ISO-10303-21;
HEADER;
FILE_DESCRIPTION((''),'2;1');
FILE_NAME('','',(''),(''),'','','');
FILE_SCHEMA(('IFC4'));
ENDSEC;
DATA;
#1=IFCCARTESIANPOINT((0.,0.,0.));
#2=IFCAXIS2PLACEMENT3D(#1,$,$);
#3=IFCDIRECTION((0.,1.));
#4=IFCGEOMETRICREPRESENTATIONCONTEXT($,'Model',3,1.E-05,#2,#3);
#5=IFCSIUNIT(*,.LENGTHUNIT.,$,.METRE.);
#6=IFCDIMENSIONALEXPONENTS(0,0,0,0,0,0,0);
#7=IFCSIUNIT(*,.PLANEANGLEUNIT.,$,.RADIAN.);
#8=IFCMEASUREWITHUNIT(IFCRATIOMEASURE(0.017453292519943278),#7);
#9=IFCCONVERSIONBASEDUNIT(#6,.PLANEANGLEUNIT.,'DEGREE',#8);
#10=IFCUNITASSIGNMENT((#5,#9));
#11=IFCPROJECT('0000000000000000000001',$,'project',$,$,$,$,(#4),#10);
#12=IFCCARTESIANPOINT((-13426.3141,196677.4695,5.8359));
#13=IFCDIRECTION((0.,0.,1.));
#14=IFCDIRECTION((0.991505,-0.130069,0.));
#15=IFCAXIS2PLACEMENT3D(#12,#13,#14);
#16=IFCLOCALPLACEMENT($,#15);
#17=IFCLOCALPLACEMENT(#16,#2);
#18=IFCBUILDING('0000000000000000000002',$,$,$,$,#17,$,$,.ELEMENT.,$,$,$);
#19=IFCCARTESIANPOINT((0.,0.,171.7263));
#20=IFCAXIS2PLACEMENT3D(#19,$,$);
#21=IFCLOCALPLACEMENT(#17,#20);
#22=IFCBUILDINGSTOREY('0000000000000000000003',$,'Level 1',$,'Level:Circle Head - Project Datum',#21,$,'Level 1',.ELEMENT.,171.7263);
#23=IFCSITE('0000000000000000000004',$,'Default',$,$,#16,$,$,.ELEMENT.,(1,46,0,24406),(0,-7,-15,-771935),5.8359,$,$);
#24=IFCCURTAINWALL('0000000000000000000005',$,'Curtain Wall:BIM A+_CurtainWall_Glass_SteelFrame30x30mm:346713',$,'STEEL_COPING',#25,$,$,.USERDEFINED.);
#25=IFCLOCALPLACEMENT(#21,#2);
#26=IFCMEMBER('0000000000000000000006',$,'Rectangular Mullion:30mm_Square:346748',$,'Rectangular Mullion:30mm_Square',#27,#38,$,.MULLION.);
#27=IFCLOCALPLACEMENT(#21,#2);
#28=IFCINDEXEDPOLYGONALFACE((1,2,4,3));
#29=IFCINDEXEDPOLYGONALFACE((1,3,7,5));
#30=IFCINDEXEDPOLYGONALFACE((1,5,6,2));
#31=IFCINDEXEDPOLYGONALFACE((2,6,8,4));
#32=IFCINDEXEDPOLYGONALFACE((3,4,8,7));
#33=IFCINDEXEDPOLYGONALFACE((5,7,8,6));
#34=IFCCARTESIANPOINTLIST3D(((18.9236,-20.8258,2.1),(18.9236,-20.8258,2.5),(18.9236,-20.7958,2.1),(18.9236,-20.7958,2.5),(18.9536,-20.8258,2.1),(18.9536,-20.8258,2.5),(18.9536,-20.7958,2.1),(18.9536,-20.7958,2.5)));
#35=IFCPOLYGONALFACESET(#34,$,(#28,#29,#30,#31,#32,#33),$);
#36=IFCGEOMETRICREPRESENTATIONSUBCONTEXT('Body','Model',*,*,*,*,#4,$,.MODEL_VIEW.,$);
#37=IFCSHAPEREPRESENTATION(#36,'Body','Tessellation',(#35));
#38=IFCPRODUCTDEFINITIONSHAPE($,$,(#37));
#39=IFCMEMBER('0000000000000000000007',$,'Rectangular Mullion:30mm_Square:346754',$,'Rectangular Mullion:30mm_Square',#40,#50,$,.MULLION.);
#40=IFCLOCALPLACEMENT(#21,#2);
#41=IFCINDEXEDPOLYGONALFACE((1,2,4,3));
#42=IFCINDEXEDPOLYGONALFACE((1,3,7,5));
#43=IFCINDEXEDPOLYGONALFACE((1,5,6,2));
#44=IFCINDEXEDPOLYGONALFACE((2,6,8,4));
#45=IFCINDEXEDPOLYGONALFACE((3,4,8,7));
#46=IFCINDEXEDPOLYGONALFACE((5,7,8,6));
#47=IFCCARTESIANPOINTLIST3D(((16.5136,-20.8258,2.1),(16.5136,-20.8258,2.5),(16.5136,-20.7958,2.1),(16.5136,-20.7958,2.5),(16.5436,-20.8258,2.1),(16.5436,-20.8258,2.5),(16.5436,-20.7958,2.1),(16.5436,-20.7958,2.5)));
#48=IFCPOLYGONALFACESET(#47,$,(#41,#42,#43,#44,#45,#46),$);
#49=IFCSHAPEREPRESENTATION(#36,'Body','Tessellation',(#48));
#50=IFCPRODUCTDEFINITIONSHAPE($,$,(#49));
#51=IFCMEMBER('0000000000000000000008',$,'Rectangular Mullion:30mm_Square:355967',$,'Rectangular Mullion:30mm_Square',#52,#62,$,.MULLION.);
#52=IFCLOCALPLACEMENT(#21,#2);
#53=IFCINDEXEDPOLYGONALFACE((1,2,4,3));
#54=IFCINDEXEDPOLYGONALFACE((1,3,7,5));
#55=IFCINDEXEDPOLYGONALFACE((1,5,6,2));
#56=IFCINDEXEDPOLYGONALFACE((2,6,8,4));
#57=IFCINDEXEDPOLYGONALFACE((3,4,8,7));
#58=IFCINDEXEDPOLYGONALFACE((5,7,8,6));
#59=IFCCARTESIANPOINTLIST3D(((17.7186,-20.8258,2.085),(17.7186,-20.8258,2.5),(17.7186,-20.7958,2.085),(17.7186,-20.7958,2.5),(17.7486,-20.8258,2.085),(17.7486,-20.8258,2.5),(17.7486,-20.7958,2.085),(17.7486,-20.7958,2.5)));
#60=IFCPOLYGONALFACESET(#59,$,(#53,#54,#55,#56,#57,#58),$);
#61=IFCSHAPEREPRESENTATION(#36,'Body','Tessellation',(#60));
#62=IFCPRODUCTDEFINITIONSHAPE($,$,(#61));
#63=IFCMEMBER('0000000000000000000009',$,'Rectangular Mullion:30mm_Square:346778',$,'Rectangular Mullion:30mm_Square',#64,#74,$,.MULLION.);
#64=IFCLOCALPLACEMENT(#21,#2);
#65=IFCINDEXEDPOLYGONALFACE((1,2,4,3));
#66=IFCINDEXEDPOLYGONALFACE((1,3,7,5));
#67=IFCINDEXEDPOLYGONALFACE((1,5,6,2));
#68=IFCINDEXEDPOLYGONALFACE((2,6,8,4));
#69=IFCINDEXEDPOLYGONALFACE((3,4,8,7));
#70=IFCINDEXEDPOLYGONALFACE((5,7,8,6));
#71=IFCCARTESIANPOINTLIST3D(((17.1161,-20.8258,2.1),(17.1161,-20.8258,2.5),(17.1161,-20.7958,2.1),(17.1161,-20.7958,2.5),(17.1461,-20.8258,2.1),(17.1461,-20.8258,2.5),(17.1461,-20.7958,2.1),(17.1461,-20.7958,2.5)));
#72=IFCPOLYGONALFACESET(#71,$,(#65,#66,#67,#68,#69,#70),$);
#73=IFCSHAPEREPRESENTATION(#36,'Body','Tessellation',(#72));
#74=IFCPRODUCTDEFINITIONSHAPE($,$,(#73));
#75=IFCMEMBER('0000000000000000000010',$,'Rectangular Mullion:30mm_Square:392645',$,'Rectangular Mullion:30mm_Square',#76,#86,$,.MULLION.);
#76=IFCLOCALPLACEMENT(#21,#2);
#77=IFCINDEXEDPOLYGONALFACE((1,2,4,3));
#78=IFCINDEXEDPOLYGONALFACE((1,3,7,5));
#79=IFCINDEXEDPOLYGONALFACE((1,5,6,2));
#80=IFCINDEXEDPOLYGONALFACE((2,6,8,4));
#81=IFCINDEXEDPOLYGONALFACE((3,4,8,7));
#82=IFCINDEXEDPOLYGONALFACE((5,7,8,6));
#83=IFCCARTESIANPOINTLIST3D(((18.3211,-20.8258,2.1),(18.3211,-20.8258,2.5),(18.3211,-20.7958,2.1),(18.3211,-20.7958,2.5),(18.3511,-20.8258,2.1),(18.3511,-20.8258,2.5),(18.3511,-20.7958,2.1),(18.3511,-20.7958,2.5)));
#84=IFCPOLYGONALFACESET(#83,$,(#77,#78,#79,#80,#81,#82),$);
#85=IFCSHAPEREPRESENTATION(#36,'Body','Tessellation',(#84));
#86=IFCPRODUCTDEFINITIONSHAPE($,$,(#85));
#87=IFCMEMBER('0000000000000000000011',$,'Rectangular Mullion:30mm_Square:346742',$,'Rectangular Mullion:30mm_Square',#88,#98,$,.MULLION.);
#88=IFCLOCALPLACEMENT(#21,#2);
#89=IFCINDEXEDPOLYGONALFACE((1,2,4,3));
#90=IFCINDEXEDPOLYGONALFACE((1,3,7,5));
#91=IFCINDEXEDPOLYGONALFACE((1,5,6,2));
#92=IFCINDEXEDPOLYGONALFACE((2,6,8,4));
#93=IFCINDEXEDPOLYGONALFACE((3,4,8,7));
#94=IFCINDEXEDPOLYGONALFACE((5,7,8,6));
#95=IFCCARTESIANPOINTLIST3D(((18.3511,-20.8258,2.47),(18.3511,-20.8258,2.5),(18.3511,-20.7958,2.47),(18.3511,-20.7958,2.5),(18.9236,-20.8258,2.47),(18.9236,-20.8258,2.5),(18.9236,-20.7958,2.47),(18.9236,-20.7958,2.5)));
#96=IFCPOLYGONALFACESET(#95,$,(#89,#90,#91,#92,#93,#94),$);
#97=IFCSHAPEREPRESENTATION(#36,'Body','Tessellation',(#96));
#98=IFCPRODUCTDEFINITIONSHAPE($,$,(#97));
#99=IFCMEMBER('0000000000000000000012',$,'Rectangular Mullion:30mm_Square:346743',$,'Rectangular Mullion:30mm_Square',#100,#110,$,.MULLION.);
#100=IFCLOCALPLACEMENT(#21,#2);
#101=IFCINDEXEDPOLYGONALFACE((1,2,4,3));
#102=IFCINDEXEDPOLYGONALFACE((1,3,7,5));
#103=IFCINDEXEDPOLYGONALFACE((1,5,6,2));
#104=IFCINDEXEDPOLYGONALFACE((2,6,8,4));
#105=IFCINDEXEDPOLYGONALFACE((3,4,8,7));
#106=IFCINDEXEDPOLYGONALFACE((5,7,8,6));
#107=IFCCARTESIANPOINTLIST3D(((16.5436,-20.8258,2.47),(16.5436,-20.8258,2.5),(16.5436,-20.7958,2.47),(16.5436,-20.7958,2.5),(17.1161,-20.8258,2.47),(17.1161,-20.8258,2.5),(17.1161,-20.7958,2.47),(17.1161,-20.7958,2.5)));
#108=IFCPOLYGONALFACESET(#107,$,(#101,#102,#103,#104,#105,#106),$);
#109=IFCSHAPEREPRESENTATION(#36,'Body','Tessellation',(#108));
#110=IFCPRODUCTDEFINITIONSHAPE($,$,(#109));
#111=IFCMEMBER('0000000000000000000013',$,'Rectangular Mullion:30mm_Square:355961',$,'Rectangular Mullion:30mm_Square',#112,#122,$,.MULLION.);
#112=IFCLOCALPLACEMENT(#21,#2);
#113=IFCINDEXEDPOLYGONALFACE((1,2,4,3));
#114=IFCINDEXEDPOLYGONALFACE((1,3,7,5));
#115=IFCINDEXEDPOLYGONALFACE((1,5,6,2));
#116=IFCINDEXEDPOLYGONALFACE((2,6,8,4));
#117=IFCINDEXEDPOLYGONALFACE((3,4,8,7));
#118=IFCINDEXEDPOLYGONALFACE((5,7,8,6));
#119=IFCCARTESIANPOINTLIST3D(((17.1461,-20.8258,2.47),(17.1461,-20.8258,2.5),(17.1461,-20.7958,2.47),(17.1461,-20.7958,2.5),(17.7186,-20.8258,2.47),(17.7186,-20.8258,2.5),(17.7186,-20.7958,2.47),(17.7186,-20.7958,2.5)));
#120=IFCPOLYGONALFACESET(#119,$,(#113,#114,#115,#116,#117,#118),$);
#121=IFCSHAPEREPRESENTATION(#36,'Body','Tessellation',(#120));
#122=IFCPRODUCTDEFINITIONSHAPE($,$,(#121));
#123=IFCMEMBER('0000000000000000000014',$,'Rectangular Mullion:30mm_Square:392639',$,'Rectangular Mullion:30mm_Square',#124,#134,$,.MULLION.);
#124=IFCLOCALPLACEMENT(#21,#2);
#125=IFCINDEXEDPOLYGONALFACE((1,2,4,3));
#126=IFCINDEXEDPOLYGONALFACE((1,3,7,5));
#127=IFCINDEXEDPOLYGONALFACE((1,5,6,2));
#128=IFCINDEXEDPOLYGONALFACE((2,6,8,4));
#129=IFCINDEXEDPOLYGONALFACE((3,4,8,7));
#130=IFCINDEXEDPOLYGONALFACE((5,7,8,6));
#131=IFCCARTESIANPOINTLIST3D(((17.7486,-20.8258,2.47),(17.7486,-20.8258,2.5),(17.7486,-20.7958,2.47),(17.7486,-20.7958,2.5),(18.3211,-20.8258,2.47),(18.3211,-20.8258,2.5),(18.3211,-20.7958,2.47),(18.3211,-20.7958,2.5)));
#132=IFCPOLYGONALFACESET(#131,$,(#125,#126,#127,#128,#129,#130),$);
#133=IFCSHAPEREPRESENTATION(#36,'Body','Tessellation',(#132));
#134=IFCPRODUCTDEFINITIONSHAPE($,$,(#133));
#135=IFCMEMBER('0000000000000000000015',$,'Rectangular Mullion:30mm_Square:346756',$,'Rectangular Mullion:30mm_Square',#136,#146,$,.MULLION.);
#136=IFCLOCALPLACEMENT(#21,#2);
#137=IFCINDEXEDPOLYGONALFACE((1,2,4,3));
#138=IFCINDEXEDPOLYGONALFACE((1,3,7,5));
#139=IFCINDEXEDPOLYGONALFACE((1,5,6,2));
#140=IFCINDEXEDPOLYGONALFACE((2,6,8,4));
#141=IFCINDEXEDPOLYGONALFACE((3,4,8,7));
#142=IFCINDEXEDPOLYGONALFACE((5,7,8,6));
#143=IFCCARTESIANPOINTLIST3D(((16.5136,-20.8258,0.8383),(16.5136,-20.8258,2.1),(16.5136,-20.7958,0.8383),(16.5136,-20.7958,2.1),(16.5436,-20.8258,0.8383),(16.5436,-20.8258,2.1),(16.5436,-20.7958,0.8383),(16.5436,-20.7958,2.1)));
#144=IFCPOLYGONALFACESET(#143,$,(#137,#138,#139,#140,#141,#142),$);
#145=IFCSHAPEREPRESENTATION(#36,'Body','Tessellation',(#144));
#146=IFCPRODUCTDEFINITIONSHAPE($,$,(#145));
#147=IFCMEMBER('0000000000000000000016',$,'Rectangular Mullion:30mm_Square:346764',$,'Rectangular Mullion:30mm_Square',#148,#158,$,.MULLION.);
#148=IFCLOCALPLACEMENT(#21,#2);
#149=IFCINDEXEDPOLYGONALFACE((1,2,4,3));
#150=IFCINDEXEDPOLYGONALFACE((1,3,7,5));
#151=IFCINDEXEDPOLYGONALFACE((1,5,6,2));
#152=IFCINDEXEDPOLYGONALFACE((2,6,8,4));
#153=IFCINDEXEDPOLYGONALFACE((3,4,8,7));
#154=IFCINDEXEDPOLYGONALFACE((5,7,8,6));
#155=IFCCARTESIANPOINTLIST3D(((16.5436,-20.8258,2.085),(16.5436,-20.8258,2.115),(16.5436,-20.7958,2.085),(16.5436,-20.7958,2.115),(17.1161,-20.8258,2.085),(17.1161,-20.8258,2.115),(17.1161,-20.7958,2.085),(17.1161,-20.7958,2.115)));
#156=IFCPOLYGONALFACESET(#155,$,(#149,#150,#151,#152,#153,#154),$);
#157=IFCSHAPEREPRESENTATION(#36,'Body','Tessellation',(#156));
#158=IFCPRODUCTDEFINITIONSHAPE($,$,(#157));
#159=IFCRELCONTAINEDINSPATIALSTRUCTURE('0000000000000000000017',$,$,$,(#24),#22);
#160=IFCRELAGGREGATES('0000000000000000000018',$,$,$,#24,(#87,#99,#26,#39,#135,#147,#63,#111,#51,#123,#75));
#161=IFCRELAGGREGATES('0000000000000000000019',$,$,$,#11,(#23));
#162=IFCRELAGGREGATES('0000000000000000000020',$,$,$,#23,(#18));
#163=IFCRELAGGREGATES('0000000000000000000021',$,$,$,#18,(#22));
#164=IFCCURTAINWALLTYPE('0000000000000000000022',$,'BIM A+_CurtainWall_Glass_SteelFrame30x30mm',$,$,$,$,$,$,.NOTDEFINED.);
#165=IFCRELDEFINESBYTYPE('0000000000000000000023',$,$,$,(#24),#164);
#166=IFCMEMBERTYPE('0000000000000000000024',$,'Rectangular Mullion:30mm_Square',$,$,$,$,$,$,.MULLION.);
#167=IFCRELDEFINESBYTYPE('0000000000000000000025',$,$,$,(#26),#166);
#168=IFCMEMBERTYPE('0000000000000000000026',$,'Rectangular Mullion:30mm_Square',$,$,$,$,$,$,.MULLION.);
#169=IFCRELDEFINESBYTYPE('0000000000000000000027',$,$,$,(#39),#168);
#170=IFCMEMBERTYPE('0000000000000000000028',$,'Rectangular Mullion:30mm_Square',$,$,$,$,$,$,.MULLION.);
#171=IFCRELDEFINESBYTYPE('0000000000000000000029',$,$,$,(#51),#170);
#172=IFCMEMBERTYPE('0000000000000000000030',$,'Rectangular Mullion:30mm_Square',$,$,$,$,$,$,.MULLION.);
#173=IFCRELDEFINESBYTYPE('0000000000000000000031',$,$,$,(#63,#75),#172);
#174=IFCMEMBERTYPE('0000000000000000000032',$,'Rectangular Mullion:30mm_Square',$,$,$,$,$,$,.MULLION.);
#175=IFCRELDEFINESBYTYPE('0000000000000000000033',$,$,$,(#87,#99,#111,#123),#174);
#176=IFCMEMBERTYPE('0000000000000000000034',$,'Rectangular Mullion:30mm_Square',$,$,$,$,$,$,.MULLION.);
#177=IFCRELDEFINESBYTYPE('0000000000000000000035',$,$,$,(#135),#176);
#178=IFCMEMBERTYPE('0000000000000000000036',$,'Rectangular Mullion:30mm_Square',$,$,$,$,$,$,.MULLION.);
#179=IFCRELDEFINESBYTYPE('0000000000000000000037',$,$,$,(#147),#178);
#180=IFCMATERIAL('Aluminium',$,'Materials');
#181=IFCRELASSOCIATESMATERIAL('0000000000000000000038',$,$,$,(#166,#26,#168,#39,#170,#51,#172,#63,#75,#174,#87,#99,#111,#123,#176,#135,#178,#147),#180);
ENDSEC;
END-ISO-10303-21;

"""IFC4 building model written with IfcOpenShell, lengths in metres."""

from ifc_helpers import new_model, entity, si_unit, converted_unit, direction, frame, origin, place, context, subcontext, project, spatial, indexed_curve, outline, extrude, source, transform, mapped, material, type_object, type_shapes, element, aggregate, save


model = new_model("IFC4")

# Units and contexts
model_context = context("Model", 3, precision=1e-05, world=origin(), true_north=direction((0.0, 1.0)))
body_context = subcontext(model_context, "Body", "Model", "MODEL_VIEW")
ifc_project = project(units=[si_unit("LENGTHUNIT", "METRE"), converted_unit("PLANEANGLEUNIT", "DEGREE", entity("IfcRatioMeasure", 0.017453292519943278), si_unit("PLANEANGLEUNIT", "RADIAN"), dimensions=[0, 0, 0, 0, 0, 0, 0])], contexts=[model_context])

# Site, building, storey
site_placement = place(None, frame((-13426.3141, 196677.4695, 5.8359), z_axis=(0.0, 0.0, 1.0), x_axis=(0.991505, -0.130069, 0.0)))
site = spatial("IfcSite", under=ifc_project, at=site_placement, Name="Default", CompositionType="ELEMENT", RefLatitude=(1, 46, 0, 24406), RefLongitude=(0, -7, -15, -771935), RefElevation=5.8359)
building_placement = place(site_placement, origin())
building = spatial("IfcBuilding", under=site, at=building_placement, CompositionType="ELEMENT")
storey_placement = place(building_placement, frame((0.0, 0.0, 171.7263)))
storey = spatial("IfcBuildingStorey", under=building, at=storey_placement, Name="Level 1", ObjectType="Level:Circle Head - Project Datum", LongName="Level 1", CompositionType="ELEMENT", Elevation=171.7263)

# Curtain wall, members
curtain_wall_type_1 = type_object("IfcCurtainWallType", Name="BIM A+_CurtainWall_Glass_SteelFrame30x30mm", PredefinedType="NOTDEFINED")
curtain_wall_1_placement = place(storey_placement, frame((0.0, 0.0, -171.7263)))
curtain_wall_1 = element("IfcCurtainWall", 1, at=curtain_wall_1_placement, inside=storey, type_object=curtain_wall_type_1, Name="Curtain Wall:BIM A+_CurtainWall_Glass_SteelFrame30x30mm:346713", ObjectType="STEEL_COPING", PredefinedType="USERDEFINED")
ifc_material_1 = material(Name="Aluminium", Category="Materials")
member_type_1 = type_object("IfcMemberType", Name="Rectangular Mullion:30mm_Square", PredefinedType="MULLION", material=ifc_material_1)
shared_shape_1 = source(origin(), body_context, "Body", "SweptSolid", [
    extrude(outline(indexed_curve([(-0.015, -0.015), (0.015, -0.015), (0.015, 0.015), (-0.015, 0.015), (-0.015, -0.015)], self_intersect=False)), frame((-0.015, 0.0, -0.4), z_axis=(0.0, 0.0, 1.0), x_axis=(0.0, -1.0, 0.0)), (0.0, 0.0, 1.0), 0.4),
])
type_shapes(member_type_1, [shared_shape_1])
member_1_placement = place(curtain_wall_1_placement, frame((18.9536, -20.8108, 173.8263), z_axis=(0.0, 0.0, -1.0), x_axis=(1.0, 0.0, 0.0)))
member_1 = element("IfcMember", 2, at=member_1_placement, type_object=member_type_1, material=ifc_material_1, Name="Rectangular Mullion:30mm_Square:346748", ObjectType="Rectangular Mullion:30mm_Square", PredefinedType="MULLION", context=body_context, shape_type="MappedRepresentation", body=[
    mapped(shared_shape_1, transform((0.0, 0.0, 0.0), scale=1.0)),
])
member_type_2 = type_object("IfcMemberType", Name="Rectangular Mullion:30mm_Square", PredefinedType="MULLION", material=ifc_material_1)
shared_shape_2 = source(origin(), body_context, "Body", "SweptSolid", [
    extrude(outline(indexed_curve([(-0.015, -0.015), (0.015, -0.015), (0.015, 0.015), (-0.015, 0.015), (-0.015, -0.015)], self_intersect=False)), frame((-0.015, 0.0, -0.4), z_axis=(0.0, 0.0, 1.0), x_axis=(0.0, -1.0, 0.0)), (0.0, 0.0, 1.0), 0.4),
])
type_shapes(member_type_2, [shared_shape_2])
member_2_placement = place(curtain_wall_1_placement, frame((16.5136, -20.8108, 174.2263), z_axis=(0.0, 0.0, 1.0), x_axis=(-1.0, 0.0, 0.0)))
member_2 = element("IfcMember", 3, at=member_2_placement, type_object=member_type_2, material=ifc_material_1, Name="Rectangular Mullion:30mm_Square:346754", ObjectType="Rectangular Mullion:30mm_Square", PredefinedType="MULLION", context=body_context, shape_type="MappedRepresentation", body=[
    mapped(shared_shape_2, transform((0.0, 0.0, 0.0), scale=1.0)),
])
member_type_3 = type_object("IfcMemberType", Name="Rectangular Mullion:30mm_Square", PredefinedType="MULLION", material=ifc_material_1)
shared_shape_3 = source(origin(), body_context, "Body", "SweptSolid", [
    extrude(outline(indexed_curve([(-0.015, -0.015), (0.015, -0.015), (0.015, 0.015), (-0.015, 0.015), (-0.015, -0.015)], self_intersect=False)), frame((0.0, 0.0, -0.415), z_axis=(0.0, 0.0, 1.0), x_axis=(0.0, -1.0, 0.0)), (0.0, 0.0, 1.0), 0.415),
])
type_shapes(member_type_3, [shared_shape_3])
member_3_placement = place(curtain_wall_1_placement, frame((17.7336, -20.8108, 173.8113), z_axis=(0.0, 0.0, -1.0), x_axis=(1.0, 0.0, 0.0)))
member_3 = element("IfcMember", 4, at=member_3_placement, type_object=member_type_3, material=ifc_material_1, Name="Rectangular Mullion:30mm_Square:355967", ObjectType="Rectangular Mullion:30mm_Square", PredefinedType="MULLION", context=body_context, shape_type="MappedRepresentation", body=[
    mapped(shared_shape_3, transform((0.0, 0.0, 0.0), scale=1.0)),
])
member_type_4 = type_object("IfcMemberType", Name="Rectangular Mullion:30mm_Square", PredefinedType="MULLION", material=ifc_material_1)
shared_shape_4 = source(origin(), body_context, "Body", "SweptSolid", [
    extrude(outline(indexed_curve([(-0.015, -0.015), (0.015, -0.015), (0.015, 0.015), (-0.015, 0.015), (-0.015, -0.015)], self_intersect=False)), frame((0.0, 0.0, -0.4), z_axis=(0.0, 0.0, 1.0), x_axis=(0.0, -1.0, 0.0)), (0.0, 0.0, 1.0), 0.4),
])
type_shapes(member_type_4, [shared_shape_4])
member_4_placement = place(curtain_wall_1_placement, frame((17.1311, -20.8108, 173.8263), z_axis=(0.0, 0.0, -1.0), x_axis=(1.0, 0.0, 0.0)))
member_4 = element("IfcMember", 5, at=member_4_placement, type_object=member_type_4, material=ifc_material_1, Name="Rectangular Mullion:30mm_Square:346778", ObjectType="Rectangular Mullion:30mm_Square", PredefinedType="MULLION", context=body_context, shape_type="MappedRepresentation", body=[
    mapped(shared_shape_4, transform((0.0, 0.0, 0.0), scale=1.0)),
])
member_5_placement = place(curtain_wall_1_placement, frame((18.3361, -20.8108, 173.8263), z_axis=(0.0, 0.0, -1.0), x_axis=(1.0, 0.0, 0.0)))
member_5 = element("IfcMember", 6, at=member_5_placement, type_object=member_type_4, material=ifc_material_1, Name="Rectangular Mullion:30mm_Square:392645", ObjectType="Rectangular Mullion:30mm_Square", PredefinedType="MULLION", context=body_context, shape_type="MappedRepresentation", body=[
    mapped(shared_shape_4, transform((0.0, 0.0, 0.0), scale=1.0)),
])
member_type_5 = type_object("IfcMemberType", Name="Rectangular Mullion:30mm_Square", PredefinedType="MULLION", material=ifc_material_1)
shared_shape_5 = source(origin(), body_context, "Body", "SweptSolid", [
    extrude(outline(indexed_curve([(-0.015, -0.015), (0.015, -0.015), (0.015, 0.015), (-0.015, 0.015), (-0.015, -0.015)], self_intersect=False)), frame((-0.015, 0.0, -0.5725), z_axis=(0.0, 0.0, 1.0), x_axis=(0.0, -1.0, 0.0)), (0.0, 0.0, 1.0), 0.5725),
])
type_shapes(member_type_5, [shared_shape_5])
member_6_placement = place(curtain_wall_1_placement, frame((18.9236, -20.8108, 174.2263), z_axis=(1.0, 0.0, 0.0), x_axis=(0.0, 0.0, 1.0)))
member_6 = element("IfcMember", 7, at=member_6_placement, type_object=member_type_5, material=ifc_material_1, Name="Rectangular Mullion:30mm_Square:346742", ObjectType="Rectangular Mullion:30mm_Square", PredefinedType="MULLION", context=body_context, shape_type="MappedRepresentation", body=[
    mapped(shared_shape_5, transform((0.0, 0.0, 0.0), scale=1.0)),
])
member_7_placement = place(curtain_wall_1_placement, frame((17.1161, -20.8108, 174.2263), z_axis=(1.0, 0.0, 0.0), x_axis=(0.0, 0.0, 1.0)))
member_7 = element("IfcMember", 8, at=member_7_placement, type_object=member_type_5, material=ifc_material_1, Name="Rectangular Mullion:30mm_Square:346743", ObjectType="Rectangular Mullion:30mm_Square", PredefinedType="MULLION", context=body_context, shape_type="MappedRepresentation", body=[
    mapped(shared_shape_5, transform((0.0, 0.0, 0.0), scale=1.0)),
])
member_8_placement = place(curtain_wall_1_placement, frame((17.7186, -20.8108, 174.2263), z_axis=(1.0, 0.0, 0.0), x_axis=(0.0, 0.0, 1.0)))
member_8 = element("IfcMember", 9, at=member_8_placement, type_object=member_type_5, material=ifc_material_1, Name="Rectangular Mullion:30mm_Square:355961", ObjectType="Rectangular Mullion:30mm_Square", PredefinedType="MULLION", context=body_context, shape_type="MappedRepresentation", body=[
    mapped(shared_shape_5, transform((0.0, 0.0, 0.0), scale=1.0)),
])
member_9_placement = place(curtain_wall_1_placement, frame((18.3211, -20.8108, 174.2263), z_axis=(1.0, 0.0, 0.0), x_axis=(0.0, 0.0, 1.0)))
member_9 = element("IfcMember", 10, at=member_9_placement, type_object=member_type_5, material=ifc_material_1, Name="Rectangular Mullion:30mm_Square:392639", ObjectType="Rectangular Mullion:30mm_Square", PredefinedType="MULLION", context=body_context, shape_type="MappedRepresentation", body=[
    mapped(shared_shape_5, transform((0.0, 0.0, 0.0), scale=1.0)),
])
member_type_6 = type_object("IfcMemberType", Name="Rectangular Mullion:30mm_Square", PredefinedType="MULLION", material=ifc_material_1)
shared_shape_6 = source(origin(), body_context, "Body", "SweptSolid", [
    extrude(outline(indexed_curve([(-0.015, -0.015), (0.015, -0.015), (0.015, 0.015), (-0.015, 0.015), (-0.015, -0.015)], self_intersect=False)), frame((-0.015, 0.0, -1.2617), z_axis=(0.0, 0.0, 1.0), x_axis=(0.0, -1.0, 0.0)), (0.0, 0.0, 1.0), 1.2617),
])
type_shapes(member_type_6, [shared_shape_6])
member_10_placement = place(curtain_wall_1_placement, frame((16.5136, -20.8108, 173.8263), z_axis=(0.0, 0.0, 1.0), x_axis=(-1.0, 0.0, 0.0)))
member_10 = element("IfcMember", 11, at=member_10_placement, type_object=member_type_6, material=ifc_material_1, Name="Rectangular Mullion:30mm_Square:346756", ObjectType="Rectangular Mullion:30mm_Square", PredefinedType="MULLION", context=body_context, shape_type="MappedRepresentation", body=[
    mapped(shared_shape_6, transform((0.0, 0.0, 0.0), scale=1.0)),
])
member_type_7 = type_object("IfcMemberType", Name="Rectangular Mullion:30mm_Square", PredefinedType="MULLION", material=ifc_material_1)
shared_shape_7 = source(origin(), body_context, "Body", "SweptSolid", [
    extrude(outline(indexed_curve([(-0.015, -0.015), (0.015, -0.015), (0.015, 0.015), (-0.015, 0.015), (-0.015, -0.015)], self_intersect=False)), frame((0.0, 0.0, -0.5725), z_axis=(0.0, 0.0, 1.0), x_axis=(0.0, -1.0, 0.0)), (0.0, 0.0, 1.0), 0.5725),
])
type_shapes(member_type_7, [shared_shape_7])
member_11_placement = place(curtain_wall_1_placement, frame((17.1161, -20.8108, 173.8263), z_axis=(1.0, 0.0, 0.0), x_axis=(0.0, 0.0, 1.0)))
member_11 = element("IfcMember", 12, at=member_11_placement, type_object=member_type_7, material=ifc_material_1, Name="Rectangular Mullion:30mm_Square:346764", ObjectType="Rectangular Mullion:30mm_Square", PredefinedType="MULLION", context=body_context, shape_type="MappedRepresentation", body=[
    mapped(shared_shape_7, transform((0.0, 0.0, 0.0), scale=1.0)),
])

aggregate(curtain_wall_1, [member_6, member_7, member_1, member_2, member_10, member_11, member_4, member_8, member_3, member_9, member_5])

save(model, "model.ifc")
